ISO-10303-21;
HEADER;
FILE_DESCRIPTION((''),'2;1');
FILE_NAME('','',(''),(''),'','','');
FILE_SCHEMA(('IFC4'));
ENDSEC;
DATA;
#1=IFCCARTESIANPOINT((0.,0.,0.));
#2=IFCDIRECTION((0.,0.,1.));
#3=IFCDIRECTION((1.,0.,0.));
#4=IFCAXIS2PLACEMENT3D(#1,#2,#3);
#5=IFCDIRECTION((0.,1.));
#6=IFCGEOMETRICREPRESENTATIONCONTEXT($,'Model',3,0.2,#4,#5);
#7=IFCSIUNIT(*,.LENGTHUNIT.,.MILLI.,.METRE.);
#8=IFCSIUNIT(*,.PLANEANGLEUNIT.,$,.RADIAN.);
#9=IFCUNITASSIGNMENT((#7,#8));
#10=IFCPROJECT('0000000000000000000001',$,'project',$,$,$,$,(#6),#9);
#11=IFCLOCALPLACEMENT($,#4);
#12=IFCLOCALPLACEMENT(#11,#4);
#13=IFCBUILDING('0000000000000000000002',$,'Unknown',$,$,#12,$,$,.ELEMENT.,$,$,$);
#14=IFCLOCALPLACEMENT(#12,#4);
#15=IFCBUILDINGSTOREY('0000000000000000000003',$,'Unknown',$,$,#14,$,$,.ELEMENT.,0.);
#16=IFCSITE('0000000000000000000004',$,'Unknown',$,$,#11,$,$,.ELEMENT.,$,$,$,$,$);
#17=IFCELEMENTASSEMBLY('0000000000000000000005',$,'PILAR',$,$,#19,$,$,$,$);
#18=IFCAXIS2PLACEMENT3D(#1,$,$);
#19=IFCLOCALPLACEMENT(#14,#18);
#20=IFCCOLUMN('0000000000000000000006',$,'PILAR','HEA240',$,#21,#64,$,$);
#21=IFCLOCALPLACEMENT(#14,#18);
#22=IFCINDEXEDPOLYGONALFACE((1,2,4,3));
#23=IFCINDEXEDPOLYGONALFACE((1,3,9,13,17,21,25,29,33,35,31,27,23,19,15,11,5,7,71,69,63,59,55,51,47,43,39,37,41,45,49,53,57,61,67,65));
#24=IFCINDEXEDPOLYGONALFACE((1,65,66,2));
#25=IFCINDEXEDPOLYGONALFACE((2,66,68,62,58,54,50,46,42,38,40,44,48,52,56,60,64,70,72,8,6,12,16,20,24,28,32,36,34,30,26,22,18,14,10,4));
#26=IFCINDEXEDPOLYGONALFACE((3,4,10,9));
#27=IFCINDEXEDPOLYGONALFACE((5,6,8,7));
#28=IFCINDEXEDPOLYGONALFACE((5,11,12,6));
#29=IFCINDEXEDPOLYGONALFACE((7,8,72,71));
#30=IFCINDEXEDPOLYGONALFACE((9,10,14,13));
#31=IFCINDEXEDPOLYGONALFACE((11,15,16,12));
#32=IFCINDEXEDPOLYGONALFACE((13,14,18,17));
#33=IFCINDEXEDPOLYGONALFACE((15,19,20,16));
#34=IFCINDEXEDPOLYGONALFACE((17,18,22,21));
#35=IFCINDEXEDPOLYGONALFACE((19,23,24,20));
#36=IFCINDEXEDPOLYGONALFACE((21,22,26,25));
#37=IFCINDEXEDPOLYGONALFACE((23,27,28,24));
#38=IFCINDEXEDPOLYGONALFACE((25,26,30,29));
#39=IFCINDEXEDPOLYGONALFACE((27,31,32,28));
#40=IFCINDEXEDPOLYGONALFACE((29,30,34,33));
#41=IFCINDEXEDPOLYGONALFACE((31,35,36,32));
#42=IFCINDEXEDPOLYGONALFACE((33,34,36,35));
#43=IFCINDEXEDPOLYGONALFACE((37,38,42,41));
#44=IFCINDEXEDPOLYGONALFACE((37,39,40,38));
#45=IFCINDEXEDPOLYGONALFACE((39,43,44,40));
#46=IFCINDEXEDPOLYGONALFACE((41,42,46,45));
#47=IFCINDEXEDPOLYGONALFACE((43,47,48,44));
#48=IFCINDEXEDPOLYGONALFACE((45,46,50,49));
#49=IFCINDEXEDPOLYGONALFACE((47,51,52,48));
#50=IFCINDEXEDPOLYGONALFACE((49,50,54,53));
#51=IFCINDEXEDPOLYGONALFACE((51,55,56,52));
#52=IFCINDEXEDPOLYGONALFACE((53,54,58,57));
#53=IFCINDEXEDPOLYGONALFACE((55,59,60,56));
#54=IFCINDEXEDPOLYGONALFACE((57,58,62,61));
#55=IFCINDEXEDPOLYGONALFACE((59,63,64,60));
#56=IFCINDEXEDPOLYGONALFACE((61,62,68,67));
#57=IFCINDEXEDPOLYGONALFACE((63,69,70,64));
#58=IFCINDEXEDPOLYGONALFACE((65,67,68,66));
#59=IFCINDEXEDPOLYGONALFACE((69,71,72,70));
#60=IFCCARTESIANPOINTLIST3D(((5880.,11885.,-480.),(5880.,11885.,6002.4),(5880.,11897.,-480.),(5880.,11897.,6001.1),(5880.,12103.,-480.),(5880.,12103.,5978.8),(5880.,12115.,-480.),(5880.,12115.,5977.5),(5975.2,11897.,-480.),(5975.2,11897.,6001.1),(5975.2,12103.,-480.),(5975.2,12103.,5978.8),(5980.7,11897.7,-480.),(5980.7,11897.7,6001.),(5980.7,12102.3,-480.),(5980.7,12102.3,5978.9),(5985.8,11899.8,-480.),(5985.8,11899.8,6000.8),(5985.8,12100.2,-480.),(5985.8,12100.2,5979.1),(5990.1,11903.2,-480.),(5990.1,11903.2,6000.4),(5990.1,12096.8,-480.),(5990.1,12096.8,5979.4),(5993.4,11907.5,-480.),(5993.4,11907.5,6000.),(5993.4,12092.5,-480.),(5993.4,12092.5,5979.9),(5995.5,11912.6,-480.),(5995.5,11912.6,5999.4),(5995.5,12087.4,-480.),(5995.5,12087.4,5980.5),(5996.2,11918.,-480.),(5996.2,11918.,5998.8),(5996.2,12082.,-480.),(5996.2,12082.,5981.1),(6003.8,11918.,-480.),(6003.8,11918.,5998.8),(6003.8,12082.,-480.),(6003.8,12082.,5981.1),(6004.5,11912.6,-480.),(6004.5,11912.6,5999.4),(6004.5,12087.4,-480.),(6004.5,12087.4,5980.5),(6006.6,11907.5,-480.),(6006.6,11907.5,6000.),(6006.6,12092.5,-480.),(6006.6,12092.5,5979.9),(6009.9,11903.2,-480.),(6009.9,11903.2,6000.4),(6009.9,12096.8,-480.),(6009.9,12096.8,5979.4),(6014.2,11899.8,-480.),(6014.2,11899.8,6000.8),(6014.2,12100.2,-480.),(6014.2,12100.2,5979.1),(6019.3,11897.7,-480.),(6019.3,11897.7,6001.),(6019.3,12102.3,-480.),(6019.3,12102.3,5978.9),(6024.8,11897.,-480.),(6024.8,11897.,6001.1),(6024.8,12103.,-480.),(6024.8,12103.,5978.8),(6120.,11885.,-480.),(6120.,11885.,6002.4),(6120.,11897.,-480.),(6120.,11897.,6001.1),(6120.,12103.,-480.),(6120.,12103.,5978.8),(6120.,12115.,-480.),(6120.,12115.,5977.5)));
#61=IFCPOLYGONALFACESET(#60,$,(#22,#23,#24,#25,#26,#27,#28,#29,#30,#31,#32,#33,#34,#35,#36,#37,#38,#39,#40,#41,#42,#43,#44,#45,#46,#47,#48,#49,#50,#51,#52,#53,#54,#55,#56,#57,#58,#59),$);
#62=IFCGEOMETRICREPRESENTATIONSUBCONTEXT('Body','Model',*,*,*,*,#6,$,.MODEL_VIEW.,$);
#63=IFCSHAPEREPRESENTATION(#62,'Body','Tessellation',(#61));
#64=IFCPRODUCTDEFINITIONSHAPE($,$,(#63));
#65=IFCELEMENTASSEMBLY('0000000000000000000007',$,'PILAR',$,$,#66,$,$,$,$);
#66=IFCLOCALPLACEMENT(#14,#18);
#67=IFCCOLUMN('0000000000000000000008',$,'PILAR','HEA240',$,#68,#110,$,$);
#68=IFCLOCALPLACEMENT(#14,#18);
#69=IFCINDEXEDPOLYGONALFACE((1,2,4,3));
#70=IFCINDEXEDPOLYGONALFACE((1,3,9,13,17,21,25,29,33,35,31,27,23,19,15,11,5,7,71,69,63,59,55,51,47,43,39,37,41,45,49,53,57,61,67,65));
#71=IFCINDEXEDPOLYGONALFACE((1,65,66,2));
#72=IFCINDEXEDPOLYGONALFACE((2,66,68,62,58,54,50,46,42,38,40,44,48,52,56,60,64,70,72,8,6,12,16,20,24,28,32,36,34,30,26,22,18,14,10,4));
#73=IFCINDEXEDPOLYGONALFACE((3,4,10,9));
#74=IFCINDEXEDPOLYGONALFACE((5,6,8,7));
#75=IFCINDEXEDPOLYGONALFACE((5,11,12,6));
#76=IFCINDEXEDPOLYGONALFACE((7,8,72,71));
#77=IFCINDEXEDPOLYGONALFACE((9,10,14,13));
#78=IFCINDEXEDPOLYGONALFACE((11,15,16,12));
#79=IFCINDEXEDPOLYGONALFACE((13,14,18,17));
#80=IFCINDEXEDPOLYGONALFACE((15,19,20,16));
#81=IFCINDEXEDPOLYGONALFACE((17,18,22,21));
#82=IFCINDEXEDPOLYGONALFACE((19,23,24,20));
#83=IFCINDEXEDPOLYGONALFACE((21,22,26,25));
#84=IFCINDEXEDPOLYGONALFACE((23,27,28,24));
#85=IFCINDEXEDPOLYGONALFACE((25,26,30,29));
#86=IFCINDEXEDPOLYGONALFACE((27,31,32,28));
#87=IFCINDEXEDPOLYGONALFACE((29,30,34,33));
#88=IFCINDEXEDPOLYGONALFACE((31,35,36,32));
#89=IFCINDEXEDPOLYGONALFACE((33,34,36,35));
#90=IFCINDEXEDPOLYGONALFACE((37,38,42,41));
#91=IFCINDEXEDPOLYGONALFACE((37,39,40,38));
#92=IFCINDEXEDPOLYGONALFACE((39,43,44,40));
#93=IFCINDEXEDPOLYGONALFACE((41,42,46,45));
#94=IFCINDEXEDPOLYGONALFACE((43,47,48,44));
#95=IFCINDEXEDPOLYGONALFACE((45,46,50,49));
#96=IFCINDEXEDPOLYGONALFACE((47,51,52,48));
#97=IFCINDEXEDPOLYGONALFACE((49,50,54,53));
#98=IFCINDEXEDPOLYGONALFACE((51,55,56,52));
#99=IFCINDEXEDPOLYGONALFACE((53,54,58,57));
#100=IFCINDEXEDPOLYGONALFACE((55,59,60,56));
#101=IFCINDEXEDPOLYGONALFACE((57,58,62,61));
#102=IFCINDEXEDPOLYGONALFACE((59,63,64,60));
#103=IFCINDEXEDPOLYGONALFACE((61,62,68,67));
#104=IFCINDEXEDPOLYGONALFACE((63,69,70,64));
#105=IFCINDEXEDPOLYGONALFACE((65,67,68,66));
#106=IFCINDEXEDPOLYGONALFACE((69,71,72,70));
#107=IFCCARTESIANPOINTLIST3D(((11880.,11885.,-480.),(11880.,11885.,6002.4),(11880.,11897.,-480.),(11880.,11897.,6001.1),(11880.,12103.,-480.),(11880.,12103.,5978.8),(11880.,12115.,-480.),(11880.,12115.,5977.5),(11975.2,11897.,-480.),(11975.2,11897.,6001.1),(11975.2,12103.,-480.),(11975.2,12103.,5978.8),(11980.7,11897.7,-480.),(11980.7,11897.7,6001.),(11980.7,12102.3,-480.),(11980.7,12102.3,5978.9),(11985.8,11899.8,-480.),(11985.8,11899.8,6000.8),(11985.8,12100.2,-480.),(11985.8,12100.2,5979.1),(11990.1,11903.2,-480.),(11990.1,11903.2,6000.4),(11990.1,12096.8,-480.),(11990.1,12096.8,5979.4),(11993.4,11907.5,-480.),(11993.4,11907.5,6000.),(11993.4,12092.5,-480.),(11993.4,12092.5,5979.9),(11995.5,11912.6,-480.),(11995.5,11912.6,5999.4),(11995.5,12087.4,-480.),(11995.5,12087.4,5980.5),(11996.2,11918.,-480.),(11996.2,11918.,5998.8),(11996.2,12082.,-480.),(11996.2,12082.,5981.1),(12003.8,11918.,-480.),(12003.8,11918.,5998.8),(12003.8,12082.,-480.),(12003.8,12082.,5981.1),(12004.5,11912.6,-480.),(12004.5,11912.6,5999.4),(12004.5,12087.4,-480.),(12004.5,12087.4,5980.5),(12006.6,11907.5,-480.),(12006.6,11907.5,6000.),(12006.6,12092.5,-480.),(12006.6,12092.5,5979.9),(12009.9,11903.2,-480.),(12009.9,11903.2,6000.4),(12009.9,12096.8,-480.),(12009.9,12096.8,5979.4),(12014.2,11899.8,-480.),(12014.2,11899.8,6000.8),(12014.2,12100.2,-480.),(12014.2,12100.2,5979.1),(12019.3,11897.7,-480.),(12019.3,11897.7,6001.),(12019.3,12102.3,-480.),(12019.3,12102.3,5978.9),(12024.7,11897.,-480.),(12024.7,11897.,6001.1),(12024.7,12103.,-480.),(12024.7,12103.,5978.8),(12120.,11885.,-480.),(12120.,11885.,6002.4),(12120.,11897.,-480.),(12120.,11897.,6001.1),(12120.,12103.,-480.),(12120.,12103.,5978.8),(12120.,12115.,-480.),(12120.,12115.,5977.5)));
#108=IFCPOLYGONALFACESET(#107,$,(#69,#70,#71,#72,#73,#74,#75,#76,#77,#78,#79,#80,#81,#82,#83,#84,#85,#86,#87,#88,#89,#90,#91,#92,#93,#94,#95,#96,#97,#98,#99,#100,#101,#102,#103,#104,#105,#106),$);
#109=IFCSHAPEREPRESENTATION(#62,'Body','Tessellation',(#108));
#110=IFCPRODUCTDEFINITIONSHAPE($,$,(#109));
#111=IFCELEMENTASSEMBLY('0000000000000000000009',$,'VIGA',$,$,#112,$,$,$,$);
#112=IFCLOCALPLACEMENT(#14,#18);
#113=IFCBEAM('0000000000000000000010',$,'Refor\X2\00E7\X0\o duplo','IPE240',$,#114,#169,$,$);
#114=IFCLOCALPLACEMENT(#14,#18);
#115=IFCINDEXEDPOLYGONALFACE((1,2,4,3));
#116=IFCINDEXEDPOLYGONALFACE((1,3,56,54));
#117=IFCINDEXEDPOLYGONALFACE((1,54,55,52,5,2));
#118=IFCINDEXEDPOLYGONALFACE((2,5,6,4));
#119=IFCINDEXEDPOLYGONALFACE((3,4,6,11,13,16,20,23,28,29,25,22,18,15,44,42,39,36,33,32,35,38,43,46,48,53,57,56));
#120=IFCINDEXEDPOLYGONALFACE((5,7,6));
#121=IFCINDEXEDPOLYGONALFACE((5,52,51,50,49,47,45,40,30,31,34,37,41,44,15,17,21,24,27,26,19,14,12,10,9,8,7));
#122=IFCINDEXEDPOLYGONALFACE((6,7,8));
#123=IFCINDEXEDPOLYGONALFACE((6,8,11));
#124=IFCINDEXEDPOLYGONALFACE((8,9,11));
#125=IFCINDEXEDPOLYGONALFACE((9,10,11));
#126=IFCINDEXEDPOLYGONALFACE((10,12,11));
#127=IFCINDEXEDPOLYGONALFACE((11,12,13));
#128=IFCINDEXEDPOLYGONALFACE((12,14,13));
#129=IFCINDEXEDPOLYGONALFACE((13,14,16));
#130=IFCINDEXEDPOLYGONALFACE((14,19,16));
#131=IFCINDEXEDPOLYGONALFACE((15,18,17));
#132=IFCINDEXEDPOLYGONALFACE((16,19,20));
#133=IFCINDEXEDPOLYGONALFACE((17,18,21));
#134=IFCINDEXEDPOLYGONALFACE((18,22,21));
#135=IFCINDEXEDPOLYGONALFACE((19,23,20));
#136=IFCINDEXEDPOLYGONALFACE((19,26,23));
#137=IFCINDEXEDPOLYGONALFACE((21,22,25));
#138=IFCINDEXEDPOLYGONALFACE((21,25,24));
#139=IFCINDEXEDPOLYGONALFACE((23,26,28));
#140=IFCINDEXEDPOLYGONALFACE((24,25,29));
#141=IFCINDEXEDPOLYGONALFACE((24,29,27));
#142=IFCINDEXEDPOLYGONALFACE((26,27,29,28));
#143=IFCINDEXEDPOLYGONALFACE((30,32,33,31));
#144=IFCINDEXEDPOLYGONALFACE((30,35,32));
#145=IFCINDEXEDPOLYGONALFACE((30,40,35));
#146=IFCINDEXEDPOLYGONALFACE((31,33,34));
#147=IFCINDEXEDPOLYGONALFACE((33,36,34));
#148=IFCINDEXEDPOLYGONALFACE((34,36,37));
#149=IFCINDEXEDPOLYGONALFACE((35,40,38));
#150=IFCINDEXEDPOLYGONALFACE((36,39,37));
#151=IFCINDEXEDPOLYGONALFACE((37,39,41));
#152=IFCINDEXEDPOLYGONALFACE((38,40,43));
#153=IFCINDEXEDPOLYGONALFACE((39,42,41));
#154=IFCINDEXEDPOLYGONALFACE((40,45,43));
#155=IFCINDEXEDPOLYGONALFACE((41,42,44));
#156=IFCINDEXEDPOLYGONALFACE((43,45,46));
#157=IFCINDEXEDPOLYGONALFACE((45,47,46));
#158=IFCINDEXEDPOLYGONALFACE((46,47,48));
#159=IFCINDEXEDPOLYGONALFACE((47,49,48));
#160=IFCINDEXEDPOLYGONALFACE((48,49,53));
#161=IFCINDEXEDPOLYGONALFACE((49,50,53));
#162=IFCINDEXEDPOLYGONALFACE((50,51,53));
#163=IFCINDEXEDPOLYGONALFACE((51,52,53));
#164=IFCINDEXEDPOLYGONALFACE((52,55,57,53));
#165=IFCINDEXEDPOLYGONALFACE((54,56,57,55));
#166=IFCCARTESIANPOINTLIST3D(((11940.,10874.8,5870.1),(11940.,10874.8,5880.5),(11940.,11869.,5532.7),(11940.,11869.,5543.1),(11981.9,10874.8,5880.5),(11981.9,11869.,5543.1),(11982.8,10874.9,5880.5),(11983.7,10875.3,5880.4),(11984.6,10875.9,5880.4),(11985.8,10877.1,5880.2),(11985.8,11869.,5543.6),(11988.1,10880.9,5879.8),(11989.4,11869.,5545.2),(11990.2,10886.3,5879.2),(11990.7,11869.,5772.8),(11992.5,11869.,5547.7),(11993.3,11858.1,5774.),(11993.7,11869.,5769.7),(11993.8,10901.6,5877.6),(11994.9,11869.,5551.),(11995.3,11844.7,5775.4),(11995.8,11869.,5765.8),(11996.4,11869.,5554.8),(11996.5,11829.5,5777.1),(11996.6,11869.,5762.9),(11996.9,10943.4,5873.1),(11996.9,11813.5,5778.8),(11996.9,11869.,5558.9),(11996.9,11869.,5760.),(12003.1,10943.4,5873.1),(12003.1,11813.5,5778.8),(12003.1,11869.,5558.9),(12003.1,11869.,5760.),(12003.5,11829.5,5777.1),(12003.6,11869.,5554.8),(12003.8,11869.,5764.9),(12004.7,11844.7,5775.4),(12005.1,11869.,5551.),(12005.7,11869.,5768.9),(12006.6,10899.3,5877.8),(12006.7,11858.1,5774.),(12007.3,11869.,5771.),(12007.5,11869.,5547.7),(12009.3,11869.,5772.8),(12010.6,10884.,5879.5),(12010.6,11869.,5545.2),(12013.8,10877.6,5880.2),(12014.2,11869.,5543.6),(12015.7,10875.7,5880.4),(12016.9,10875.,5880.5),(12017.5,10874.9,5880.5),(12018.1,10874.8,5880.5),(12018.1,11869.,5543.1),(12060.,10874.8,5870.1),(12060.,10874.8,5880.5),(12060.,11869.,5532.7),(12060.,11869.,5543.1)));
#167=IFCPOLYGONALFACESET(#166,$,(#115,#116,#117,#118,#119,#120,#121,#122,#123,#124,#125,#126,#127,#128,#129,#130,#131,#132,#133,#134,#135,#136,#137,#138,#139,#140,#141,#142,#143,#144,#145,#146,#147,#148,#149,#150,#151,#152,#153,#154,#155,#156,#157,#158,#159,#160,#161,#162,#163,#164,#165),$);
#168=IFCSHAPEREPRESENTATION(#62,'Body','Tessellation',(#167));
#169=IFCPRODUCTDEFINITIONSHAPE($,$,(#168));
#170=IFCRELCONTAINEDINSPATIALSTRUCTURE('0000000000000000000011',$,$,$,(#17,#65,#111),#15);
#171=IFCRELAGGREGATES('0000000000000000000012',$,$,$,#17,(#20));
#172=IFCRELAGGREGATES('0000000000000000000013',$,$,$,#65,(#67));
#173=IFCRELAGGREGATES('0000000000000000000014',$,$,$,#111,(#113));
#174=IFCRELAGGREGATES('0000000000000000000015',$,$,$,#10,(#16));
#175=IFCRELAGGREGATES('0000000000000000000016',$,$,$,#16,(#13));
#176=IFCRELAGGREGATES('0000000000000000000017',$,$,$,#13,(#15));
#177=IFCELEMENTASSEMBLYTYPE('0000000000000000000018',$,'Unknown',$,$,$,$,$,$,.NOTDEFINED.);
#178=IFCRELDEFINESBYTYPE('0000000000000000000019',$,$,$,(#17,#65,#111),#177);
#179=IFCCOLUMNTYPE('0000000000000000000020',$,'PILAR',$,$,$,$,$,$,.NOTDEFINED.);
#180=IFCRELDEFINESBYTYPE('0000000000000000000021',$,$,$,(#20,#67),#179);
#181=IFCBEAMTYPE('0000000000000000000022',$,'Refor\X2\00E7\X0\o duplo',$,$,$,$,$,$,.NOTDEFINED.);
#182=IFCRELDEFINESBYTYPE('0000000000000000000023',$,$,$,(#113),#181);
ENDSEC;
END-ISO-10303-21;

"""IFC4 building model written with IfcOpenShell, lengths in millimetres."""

from ifc_helpers import new_model, si_unit, direction, frame, origin_with_axes, origin_2d_with_axis, place, context, subcontext, project, spatial, i_section, extrude, clip, halfspace, type_object, element, aggregate, save


model = new_model("IFC4")

# Units and contexts
model_context = context("Model", 3, precision=0.2, world=origin_with_axes(), true_north=direction((0.0, 1.0)))
body_context = subcontext(model_context, "Body", "Model", "MODEL_VIEW")
ifc_project = project(units=[si_unit("LENGTHUNIT", "METRE", prefix="MILLI"), si_unit("PLANEANGLEUNIT", "RADIAN")], contexts=[model_context])

# Site, building, storey
site_placement = place(None, origin_with_axes())
site = spatial("IfcSite", under=ifc_project, at=site_placement, Name="Unknown", CompositionType="ELEMENT")
building_placement = place(site_placement, origin_with_axes())
building = spatial("IfcBuilding", under=site, at=building_placement, Name="Unknown", CompositionType="ELEMENT")
storey_placement = place(building_placement, origin_with_axes())
storey = spatial("IfcBuildingStorey", under=building, at=storey_placement, Name="Unknown", CompositionType="ELEMENT", Elevation=0.0)

# Element assemblies, columns
element_assembly_type = type_object("IfcElementAssemblyType", Name="Unknown", PredefinedType="NOTDEFINED")
assembly_1_placement = place(storey_placement, frame((6000.0, 12000.0, -500.0), z_axis=(-1.0, 0.0, 0.0), x_axis=(0.0, 0.0, 1.0)))
assembly_1 = element("IfcElementAssembly", 1, at=assembly_1_placement, inside=storey, type_object=element_assembly_type, Name="PILAR")
column_type = type_object("IfcColumnType", Name="PILAR", PredefinedType="NOTDEFINED")
column_1_placement = place(assembly_1_placement, origin_with_axes())
column_1 = element("IfcColumn", 2, at=column_1_placement, type_object=column_type, Name="PILAR", Description="HEA240", context=body_context, shape_type="Clipping", body=[
    clip(clip(extrude(i_section(OverallWidth=240.0, OverallDepth=230.0, WebThickness=7.5, FlangeThickness=12.0, FilletRadius=21.0, FlangeEdgeRadius=0.0, FlangeSlope=0.0, at=origin_2d_with_axis()), frame((-220.0, 0.0, 0.0), z_axis=(-1.0, 0.0, 0.0), x_axis=(0.0, 0.0, 1.0)), (0.0, 0.0, -1.0), 6949.9), halfspace(frame((20.0, -115.0, 0.0), z_axis=(1.0, 0.0, 0.0), x_axis=(0.0, 1.0, 0.0)), True)), halfspace(frame((6477.5, 115.0, 0.0), z_axis=(-0.994183, -0.107703, 0.0), x_axis=(0.107703, -0.994183, 0.0)), True)),
])
assembly_2_placement = place(storey_placement, frame((12000.0, 12000.0, -500.0), z_axis=(-1.0, 0.0, 0.0), x_axis=(0.0, 0.0, 1.0)))
assembly_2 = element("IfcElementAssembly", 3, at=assembly_2_placement, inside=storey, type_object=element_assembly_type, Name="PILAR")
column_2_placement = place(assembly_2_placement, origin_with_axes())
column_2 = element("IfcColumn", 4, at=column_2_placement, type_object=column_type, Name="PILAR", Description="HEA240", context=body_context, shape_type="Clipping", body=[
    clip(clip(extrude(i_section(OverallWidth=240.0, OverallDepth=230.0, WebThickness=7.5, FlangeThickness=12.0, FilletRadius=21.0, FlangeEdgeRadius=0.0, FlangeSlope=0.0, at=origin_2d_with_axis()), frame((-220.0, 0.0, 0.0), z_axis=(-1.0, 0.0, 0.0), x_axis=(0.0, 0.0, 1.0)), (0.0, 0.0, -1.0), 6949.9), halfspace(frame((20.0, -115.0, 0.0), z_axis=(1.0, 0.0, 0.0), x_axis=(0.0, 1.0, 0.0)), True)), halfspace(frame((6477.5, 115.0, 0.0), z_axis=(-0.994183, -0.107703, 0.0), x_axis=(0.107703, -0.994183, 0.0)), True)),
])

# Element assembly
assembly_3_placement = place(storey_placement, frame((12000.0, 11987.1, 5880.7), z_axis=(-1.0, 0.0, 0.0), x_axis=(0.0, -0.994183, 0.107703)))
assembly_3 = element("IfcElementAssembly", 5, at=assembly_3_placement, inside=storey, type_object=element_assembly_type, Name="VIGA")
beam_type_1 = type_object("IfcBeamType", Name="Reforço duplo", PredefinedType="NOTDEFINED")

# Beam
beam_1_placement = place(assembly_3_placement, frame((53.8, -241.6, 0.0), z_axis=(0.0, 0.0, 1.0), x_axis=(0.976051, 0.217543, 0.0)))
beam_1 = element("IfcBeam", 6, at=beam_1_placement, type_object=beam_type_1, Name="Reforço duplo", Description="IPE240", context=body_context, shape_type="Clipping", body=[
    clip(clip(clip(extrude(i_section(OverallWidth=120.0, OverallDepth=240.0, WebThickness=6.2, FlangeThickness=9.8, FilletRadius=15.0, FlangeEdgeRadius=0.0, FlangeSlope=0.0, at=origin_2d_with_axis()), frame((-199.3, 0.0, 0.0), z_axis=(-1.0, 0.0, 0.0), x_axis=(0.0, 0.0, 1.0)), (0.0, 0.0, -1.0), 1529.9), halfspace(frame((476.2, 1282.9, 0.0), z_axis=(-0.946943, 0.321401, 0.0), x_axis=(-0.321401, -0.946943, 0.0)), False)), halfspace(frame((20.4, 120.0, -60.0), z_axis=(0.217543, 0.976051, 0.0), x_axis=(0.0, 0.0, 1.0)), False)), halfspace(frame((1049.9, -120.0, 0.0), z_axis=(0.946943, -0.321401, 0.0), x_axis=(0.321401, 0.946943, 0.0)), False)),
])

aggregate(assembly_1, [column_1])
aggregate(assembly_2, [column_2])
aggregate(assembly_3, [beam_1])

save(model, "model.ifc")
